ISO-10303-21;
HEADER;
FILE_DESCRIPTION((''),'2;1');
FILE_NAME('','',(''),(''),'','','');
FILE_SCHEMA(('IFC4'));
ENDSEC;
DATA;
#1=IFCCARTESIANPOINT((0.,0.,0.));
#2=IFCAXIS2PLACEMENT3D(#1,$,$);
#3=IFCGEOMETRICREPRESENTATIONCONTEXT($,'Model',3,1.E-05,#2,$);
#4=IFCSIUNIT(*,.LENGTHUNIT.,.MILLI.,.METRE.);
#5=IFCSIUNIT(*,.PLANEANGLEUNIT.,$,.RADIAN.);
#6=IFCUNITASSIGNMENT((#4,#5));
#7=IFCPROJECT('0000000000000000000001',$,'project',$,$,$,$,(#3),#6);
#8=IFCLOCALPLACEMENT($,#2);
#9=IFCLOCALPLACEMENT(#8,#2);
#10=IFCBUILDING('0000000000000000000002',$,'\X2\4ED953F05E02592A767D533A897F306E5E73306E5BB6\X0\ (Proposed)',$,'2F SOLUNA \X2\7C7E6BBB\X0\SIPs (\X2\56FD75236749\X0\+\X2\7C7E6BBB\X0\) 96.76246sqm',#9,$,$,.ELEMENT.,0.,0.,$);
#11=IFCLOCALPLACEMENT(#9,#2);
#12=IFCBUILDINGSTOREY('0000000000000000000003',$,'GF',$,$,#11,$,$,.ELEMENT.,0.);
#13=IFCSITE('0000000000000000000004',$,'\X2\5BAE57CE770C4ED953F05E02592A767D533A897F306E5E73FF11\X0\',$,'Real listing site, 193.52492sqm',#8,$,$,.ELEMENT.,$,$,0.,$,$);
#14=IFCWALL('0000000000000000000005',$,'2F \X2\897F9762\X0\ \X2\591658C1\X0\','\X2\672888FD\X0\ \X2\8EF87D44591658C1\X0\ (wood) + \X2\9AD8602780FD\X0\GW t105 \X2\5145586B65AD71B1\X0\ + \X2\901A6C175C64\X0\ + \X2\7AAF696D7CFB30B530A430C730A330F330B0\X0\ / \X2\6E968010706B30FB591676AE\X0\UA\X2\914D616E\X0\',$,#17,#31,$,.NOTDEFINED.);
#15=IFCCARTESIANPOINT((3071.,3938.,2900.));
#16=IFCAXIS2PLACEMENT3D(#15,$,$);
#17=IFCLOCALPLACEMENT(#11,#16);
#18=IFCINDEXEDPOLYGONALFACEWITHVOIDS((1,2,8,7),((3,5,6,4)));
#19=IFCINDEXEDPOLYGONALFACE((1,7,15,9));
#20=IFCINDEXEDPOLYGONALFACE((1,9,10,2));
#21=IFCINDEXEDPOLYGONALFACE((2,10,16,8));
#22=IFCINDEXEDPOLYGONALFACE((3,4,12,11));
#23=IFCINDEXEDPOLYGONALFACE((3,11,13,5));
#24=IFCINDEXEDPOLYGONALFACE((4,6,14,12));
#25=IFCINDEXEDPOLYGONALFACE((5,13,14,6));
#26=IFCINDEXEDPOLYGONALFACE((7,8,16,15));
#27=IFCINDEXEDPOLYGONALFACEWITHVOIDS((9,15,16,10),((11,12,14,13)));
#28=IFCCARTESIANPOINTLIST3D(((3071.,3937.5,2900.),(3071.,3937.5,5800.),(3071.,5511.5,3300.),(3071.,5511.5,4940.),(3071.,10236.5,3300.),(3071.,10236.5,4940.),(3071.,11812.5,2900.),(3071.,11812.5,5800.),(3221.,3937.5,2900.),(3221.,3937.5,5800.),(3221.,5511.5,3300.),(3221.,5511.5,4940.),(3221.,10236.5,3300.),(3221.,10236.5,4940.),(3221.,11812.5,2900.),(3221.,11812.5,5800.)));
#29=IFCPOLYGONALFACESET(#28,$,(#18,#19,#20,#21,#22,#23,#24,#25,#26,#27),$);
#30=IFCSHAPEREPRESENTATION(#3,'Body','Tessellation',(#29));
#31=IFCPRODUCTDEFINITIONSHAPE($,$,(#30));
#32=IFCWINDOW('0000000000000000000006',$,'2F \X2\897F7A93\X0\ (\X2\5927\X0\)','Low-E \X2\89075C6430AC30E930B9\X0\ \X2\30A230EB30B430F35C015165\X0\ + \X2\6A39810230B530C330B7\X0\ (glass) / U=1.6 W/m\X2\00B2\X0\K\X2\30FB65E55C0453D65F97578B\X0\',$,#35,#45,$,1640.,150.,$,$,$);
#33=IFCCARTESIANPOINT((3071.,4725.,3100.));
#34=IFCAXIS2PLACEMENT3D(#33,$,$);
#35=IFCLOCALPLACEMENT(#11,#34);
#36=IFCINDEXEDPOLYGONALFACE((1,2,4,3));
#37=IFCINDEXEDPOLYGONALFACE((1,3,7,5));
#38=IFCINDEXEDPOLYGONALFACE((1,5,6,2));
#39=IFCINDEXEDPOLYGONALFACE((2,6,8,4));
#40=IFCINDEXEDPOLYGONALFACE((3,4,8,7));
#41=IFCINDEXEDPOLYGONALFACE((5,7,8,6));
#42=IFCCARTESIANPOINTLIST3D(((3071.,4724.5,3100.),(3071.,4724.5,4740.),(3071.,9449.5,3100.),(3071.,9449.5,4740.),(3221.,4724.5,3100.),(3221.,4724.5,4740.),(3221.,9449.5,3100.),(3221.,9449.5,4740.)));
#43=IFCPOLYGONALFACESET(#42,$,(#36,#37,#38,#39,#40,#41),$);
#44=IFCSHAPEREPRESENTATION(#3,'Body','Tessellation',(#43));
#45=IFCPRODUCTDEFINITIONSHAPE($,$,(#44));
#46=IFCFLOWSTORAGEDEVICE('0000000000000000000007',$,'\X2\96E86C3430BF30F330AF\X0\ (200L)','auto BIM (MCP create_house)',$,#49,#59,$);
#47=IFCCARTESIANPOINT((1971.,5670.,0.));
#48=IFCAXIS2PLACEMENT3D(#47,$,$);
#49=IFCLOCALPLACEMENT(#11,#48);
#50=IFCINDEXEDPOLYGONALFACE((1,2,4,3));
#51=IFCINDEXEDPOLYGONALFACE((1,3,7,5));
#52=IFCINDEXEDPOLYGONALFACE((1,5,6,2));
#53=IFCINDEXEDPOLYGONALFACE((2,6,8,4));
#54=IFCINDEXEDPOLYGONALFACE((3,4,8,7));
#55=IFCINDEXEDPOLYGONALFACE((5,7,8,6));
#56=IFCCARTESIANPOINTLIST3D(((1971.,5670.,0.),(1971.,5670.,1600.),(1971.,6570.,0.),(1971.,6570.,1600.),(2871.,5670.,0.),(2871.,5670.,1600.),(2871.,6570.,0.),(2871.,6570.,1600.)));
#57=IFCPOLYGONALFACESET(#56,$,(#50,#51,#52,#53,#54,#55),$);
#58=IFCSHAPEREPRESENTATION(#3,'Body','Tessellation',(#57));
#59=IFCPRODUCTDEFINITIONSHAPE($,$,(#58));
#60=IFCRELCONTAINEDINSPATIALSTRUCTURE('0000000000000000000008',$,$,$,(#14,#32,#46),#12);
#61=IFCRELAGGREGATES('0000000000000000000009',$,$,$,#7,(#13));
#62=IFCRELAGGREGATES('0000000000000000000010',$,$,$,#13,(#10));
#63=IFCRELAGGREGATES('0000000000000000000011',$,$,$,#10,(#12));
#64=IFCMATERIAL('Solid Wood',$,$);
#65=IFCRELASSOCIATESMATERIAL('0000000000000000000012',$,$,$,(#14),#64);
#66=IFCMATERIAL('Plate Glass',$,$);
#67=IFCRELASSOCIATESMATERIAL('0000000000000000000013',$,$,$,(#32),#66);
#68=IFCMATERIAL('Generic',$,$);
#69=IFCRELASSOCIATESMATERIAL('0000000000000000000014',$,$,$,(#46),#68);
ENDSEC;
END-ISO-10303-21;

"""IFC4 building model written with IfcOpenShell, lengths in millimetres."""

from ifc_helpers import new_model, si_unit, frame, frame_2d, origin, place, context, project, spatial, rectangle, extrude, material, element, fill, save


model = new_model("IFC4")

# Units and contexts
model_context = context("Model", 3, precision=1e-05, world=origin())
ifc_project = project(units=[si_unit("LENGTHUNIT", "METRE", prefix="MILLI"), si_unit("PLANEANGLEUNIT", "RADIAN")], contexts=[model_context])

# Site, building, storey
site_placement = place(None, origin())
site = spatial("IfcSite", under=ifc_project, at=site_placement, Name="宮城県仙台市太白区西の平１", ObjectType="Real listing site, 193.52492sqm", CompositionType="ELEMENT", RefElevation=0.0)
building_placement = place(site_placement, origin())
building = spatial("IfcBuilding", under=site, at=building_placement, Name="仙台市太白区西の平の家 (Proposed)", ObjectType="2F SOLUNA 籾殻SIPs (国産杉+籾殻) 96.76246sqm", CompositionType="ELEMENT", ElevationOfRefHeight=0.0, ElevationOfTerrain=0.0)
storey_placement = place(building_placement, origin())
storey = spatial("IfcBuildingStorey", under=building, at=storey_placement, Name="GF", CompositionType="ELEMENT", Elevation=0.0)

# Shared definitions
ifc_material_1 = material(Name="Solid Wood")

# Shared definitions
ifc_material_2 = material(Name="Plate Glass")

# Wall, opening, window
wall_1_placement = place(storey_placement, frame((3071.0, 3938.0, 2900.0)))
wall_1 = element("IfcWall", 1, at=wall_1_placement, inside=storey, material=ifc_material_1, Name="2F 西面 外壁", Description="木製 軸組外壁 (wood) + 高性能GW t105 充填断熱 + 通気層 + 窯業系サイディング / 準耐火・外皮UA配慮", PredefinedType="NOTDEFINED", context=model_context, shape_type="SweptSolid", body=[
    extrude(rectangle(XDim=150.0, YDim=7875.0, at=frame_2d((75.0, 3937.0))), frame((3071.0, 3938.0, 2900.0)), (0.0, 0.0, 1.0), 2900.0),
])
opening_1_placement = place(storey_placement, frame((3071.0, 4725.0, 3100.0)))
opening_1 = element("IfcOpeningElement", 2, at=opening_1_placement, cuts=wall_1, PredefinedType="NOTDEFINED", context=model_context, shape_type="SweptSolid", body=[
    extrude(rectangle(XDim=150.0, YDim=4725.0, at=frame_2d((75.0, 2362.0))), frame((3071.0, 4725.0, 3100.0)), (0.0, 0.0, 1.0), 1640.0),
])
window_1_placement = place(storey_placement, frame((3071.0, 4725.0, 3100.0)))
window_1 = element("IfcWindow", 3, at=window_1_placement, inside=storey, material=ifc_material_2, Name="2F 西窓 (大)", Description="Low-E 複層ガラス アルゴン封入 + 樹脂サッシ (glass) / U=1.6 W/m²K・日射取得型", OverallHeight=1640.0, OverallWidth=150.0, context=model_context, shape_type="SweptSolid", body=[
    extrude(rectangle(XDim=150.0, YDim=4725.0, at=frame_2d((75.0, 2362.0))), frame((3071.0, 4725.0, 3100.0)), (0.0, 0.0, 1.0), 1640.0),
])
fill(opening_1, window_1)

# Shared definitions
ifc_material_3 = material(Name="Generic")

# Flow storage device
flow_storage_device_placement = place(storey_placement, frame((1971.0, 5670.0, 0.0)))
element("IfcFlowStorageDevice", 4, at=flow_storage_device_placement, inside=storey, material=ifc_material_3, Name="雨水タンク (200L)", Description="auto BIM (MCP create_house)", context=model_context, shape_type="SweptSolid", body=[
    extrude(rectangle(XDim=900.0, YDim=900.0, at=frame_2d((450.0, 450.0))), frame((1971.0, 5670.0, 0.0)), (0.0, 0.0, 1.0), 1600.0),
])

save(model, "model.ifc")
